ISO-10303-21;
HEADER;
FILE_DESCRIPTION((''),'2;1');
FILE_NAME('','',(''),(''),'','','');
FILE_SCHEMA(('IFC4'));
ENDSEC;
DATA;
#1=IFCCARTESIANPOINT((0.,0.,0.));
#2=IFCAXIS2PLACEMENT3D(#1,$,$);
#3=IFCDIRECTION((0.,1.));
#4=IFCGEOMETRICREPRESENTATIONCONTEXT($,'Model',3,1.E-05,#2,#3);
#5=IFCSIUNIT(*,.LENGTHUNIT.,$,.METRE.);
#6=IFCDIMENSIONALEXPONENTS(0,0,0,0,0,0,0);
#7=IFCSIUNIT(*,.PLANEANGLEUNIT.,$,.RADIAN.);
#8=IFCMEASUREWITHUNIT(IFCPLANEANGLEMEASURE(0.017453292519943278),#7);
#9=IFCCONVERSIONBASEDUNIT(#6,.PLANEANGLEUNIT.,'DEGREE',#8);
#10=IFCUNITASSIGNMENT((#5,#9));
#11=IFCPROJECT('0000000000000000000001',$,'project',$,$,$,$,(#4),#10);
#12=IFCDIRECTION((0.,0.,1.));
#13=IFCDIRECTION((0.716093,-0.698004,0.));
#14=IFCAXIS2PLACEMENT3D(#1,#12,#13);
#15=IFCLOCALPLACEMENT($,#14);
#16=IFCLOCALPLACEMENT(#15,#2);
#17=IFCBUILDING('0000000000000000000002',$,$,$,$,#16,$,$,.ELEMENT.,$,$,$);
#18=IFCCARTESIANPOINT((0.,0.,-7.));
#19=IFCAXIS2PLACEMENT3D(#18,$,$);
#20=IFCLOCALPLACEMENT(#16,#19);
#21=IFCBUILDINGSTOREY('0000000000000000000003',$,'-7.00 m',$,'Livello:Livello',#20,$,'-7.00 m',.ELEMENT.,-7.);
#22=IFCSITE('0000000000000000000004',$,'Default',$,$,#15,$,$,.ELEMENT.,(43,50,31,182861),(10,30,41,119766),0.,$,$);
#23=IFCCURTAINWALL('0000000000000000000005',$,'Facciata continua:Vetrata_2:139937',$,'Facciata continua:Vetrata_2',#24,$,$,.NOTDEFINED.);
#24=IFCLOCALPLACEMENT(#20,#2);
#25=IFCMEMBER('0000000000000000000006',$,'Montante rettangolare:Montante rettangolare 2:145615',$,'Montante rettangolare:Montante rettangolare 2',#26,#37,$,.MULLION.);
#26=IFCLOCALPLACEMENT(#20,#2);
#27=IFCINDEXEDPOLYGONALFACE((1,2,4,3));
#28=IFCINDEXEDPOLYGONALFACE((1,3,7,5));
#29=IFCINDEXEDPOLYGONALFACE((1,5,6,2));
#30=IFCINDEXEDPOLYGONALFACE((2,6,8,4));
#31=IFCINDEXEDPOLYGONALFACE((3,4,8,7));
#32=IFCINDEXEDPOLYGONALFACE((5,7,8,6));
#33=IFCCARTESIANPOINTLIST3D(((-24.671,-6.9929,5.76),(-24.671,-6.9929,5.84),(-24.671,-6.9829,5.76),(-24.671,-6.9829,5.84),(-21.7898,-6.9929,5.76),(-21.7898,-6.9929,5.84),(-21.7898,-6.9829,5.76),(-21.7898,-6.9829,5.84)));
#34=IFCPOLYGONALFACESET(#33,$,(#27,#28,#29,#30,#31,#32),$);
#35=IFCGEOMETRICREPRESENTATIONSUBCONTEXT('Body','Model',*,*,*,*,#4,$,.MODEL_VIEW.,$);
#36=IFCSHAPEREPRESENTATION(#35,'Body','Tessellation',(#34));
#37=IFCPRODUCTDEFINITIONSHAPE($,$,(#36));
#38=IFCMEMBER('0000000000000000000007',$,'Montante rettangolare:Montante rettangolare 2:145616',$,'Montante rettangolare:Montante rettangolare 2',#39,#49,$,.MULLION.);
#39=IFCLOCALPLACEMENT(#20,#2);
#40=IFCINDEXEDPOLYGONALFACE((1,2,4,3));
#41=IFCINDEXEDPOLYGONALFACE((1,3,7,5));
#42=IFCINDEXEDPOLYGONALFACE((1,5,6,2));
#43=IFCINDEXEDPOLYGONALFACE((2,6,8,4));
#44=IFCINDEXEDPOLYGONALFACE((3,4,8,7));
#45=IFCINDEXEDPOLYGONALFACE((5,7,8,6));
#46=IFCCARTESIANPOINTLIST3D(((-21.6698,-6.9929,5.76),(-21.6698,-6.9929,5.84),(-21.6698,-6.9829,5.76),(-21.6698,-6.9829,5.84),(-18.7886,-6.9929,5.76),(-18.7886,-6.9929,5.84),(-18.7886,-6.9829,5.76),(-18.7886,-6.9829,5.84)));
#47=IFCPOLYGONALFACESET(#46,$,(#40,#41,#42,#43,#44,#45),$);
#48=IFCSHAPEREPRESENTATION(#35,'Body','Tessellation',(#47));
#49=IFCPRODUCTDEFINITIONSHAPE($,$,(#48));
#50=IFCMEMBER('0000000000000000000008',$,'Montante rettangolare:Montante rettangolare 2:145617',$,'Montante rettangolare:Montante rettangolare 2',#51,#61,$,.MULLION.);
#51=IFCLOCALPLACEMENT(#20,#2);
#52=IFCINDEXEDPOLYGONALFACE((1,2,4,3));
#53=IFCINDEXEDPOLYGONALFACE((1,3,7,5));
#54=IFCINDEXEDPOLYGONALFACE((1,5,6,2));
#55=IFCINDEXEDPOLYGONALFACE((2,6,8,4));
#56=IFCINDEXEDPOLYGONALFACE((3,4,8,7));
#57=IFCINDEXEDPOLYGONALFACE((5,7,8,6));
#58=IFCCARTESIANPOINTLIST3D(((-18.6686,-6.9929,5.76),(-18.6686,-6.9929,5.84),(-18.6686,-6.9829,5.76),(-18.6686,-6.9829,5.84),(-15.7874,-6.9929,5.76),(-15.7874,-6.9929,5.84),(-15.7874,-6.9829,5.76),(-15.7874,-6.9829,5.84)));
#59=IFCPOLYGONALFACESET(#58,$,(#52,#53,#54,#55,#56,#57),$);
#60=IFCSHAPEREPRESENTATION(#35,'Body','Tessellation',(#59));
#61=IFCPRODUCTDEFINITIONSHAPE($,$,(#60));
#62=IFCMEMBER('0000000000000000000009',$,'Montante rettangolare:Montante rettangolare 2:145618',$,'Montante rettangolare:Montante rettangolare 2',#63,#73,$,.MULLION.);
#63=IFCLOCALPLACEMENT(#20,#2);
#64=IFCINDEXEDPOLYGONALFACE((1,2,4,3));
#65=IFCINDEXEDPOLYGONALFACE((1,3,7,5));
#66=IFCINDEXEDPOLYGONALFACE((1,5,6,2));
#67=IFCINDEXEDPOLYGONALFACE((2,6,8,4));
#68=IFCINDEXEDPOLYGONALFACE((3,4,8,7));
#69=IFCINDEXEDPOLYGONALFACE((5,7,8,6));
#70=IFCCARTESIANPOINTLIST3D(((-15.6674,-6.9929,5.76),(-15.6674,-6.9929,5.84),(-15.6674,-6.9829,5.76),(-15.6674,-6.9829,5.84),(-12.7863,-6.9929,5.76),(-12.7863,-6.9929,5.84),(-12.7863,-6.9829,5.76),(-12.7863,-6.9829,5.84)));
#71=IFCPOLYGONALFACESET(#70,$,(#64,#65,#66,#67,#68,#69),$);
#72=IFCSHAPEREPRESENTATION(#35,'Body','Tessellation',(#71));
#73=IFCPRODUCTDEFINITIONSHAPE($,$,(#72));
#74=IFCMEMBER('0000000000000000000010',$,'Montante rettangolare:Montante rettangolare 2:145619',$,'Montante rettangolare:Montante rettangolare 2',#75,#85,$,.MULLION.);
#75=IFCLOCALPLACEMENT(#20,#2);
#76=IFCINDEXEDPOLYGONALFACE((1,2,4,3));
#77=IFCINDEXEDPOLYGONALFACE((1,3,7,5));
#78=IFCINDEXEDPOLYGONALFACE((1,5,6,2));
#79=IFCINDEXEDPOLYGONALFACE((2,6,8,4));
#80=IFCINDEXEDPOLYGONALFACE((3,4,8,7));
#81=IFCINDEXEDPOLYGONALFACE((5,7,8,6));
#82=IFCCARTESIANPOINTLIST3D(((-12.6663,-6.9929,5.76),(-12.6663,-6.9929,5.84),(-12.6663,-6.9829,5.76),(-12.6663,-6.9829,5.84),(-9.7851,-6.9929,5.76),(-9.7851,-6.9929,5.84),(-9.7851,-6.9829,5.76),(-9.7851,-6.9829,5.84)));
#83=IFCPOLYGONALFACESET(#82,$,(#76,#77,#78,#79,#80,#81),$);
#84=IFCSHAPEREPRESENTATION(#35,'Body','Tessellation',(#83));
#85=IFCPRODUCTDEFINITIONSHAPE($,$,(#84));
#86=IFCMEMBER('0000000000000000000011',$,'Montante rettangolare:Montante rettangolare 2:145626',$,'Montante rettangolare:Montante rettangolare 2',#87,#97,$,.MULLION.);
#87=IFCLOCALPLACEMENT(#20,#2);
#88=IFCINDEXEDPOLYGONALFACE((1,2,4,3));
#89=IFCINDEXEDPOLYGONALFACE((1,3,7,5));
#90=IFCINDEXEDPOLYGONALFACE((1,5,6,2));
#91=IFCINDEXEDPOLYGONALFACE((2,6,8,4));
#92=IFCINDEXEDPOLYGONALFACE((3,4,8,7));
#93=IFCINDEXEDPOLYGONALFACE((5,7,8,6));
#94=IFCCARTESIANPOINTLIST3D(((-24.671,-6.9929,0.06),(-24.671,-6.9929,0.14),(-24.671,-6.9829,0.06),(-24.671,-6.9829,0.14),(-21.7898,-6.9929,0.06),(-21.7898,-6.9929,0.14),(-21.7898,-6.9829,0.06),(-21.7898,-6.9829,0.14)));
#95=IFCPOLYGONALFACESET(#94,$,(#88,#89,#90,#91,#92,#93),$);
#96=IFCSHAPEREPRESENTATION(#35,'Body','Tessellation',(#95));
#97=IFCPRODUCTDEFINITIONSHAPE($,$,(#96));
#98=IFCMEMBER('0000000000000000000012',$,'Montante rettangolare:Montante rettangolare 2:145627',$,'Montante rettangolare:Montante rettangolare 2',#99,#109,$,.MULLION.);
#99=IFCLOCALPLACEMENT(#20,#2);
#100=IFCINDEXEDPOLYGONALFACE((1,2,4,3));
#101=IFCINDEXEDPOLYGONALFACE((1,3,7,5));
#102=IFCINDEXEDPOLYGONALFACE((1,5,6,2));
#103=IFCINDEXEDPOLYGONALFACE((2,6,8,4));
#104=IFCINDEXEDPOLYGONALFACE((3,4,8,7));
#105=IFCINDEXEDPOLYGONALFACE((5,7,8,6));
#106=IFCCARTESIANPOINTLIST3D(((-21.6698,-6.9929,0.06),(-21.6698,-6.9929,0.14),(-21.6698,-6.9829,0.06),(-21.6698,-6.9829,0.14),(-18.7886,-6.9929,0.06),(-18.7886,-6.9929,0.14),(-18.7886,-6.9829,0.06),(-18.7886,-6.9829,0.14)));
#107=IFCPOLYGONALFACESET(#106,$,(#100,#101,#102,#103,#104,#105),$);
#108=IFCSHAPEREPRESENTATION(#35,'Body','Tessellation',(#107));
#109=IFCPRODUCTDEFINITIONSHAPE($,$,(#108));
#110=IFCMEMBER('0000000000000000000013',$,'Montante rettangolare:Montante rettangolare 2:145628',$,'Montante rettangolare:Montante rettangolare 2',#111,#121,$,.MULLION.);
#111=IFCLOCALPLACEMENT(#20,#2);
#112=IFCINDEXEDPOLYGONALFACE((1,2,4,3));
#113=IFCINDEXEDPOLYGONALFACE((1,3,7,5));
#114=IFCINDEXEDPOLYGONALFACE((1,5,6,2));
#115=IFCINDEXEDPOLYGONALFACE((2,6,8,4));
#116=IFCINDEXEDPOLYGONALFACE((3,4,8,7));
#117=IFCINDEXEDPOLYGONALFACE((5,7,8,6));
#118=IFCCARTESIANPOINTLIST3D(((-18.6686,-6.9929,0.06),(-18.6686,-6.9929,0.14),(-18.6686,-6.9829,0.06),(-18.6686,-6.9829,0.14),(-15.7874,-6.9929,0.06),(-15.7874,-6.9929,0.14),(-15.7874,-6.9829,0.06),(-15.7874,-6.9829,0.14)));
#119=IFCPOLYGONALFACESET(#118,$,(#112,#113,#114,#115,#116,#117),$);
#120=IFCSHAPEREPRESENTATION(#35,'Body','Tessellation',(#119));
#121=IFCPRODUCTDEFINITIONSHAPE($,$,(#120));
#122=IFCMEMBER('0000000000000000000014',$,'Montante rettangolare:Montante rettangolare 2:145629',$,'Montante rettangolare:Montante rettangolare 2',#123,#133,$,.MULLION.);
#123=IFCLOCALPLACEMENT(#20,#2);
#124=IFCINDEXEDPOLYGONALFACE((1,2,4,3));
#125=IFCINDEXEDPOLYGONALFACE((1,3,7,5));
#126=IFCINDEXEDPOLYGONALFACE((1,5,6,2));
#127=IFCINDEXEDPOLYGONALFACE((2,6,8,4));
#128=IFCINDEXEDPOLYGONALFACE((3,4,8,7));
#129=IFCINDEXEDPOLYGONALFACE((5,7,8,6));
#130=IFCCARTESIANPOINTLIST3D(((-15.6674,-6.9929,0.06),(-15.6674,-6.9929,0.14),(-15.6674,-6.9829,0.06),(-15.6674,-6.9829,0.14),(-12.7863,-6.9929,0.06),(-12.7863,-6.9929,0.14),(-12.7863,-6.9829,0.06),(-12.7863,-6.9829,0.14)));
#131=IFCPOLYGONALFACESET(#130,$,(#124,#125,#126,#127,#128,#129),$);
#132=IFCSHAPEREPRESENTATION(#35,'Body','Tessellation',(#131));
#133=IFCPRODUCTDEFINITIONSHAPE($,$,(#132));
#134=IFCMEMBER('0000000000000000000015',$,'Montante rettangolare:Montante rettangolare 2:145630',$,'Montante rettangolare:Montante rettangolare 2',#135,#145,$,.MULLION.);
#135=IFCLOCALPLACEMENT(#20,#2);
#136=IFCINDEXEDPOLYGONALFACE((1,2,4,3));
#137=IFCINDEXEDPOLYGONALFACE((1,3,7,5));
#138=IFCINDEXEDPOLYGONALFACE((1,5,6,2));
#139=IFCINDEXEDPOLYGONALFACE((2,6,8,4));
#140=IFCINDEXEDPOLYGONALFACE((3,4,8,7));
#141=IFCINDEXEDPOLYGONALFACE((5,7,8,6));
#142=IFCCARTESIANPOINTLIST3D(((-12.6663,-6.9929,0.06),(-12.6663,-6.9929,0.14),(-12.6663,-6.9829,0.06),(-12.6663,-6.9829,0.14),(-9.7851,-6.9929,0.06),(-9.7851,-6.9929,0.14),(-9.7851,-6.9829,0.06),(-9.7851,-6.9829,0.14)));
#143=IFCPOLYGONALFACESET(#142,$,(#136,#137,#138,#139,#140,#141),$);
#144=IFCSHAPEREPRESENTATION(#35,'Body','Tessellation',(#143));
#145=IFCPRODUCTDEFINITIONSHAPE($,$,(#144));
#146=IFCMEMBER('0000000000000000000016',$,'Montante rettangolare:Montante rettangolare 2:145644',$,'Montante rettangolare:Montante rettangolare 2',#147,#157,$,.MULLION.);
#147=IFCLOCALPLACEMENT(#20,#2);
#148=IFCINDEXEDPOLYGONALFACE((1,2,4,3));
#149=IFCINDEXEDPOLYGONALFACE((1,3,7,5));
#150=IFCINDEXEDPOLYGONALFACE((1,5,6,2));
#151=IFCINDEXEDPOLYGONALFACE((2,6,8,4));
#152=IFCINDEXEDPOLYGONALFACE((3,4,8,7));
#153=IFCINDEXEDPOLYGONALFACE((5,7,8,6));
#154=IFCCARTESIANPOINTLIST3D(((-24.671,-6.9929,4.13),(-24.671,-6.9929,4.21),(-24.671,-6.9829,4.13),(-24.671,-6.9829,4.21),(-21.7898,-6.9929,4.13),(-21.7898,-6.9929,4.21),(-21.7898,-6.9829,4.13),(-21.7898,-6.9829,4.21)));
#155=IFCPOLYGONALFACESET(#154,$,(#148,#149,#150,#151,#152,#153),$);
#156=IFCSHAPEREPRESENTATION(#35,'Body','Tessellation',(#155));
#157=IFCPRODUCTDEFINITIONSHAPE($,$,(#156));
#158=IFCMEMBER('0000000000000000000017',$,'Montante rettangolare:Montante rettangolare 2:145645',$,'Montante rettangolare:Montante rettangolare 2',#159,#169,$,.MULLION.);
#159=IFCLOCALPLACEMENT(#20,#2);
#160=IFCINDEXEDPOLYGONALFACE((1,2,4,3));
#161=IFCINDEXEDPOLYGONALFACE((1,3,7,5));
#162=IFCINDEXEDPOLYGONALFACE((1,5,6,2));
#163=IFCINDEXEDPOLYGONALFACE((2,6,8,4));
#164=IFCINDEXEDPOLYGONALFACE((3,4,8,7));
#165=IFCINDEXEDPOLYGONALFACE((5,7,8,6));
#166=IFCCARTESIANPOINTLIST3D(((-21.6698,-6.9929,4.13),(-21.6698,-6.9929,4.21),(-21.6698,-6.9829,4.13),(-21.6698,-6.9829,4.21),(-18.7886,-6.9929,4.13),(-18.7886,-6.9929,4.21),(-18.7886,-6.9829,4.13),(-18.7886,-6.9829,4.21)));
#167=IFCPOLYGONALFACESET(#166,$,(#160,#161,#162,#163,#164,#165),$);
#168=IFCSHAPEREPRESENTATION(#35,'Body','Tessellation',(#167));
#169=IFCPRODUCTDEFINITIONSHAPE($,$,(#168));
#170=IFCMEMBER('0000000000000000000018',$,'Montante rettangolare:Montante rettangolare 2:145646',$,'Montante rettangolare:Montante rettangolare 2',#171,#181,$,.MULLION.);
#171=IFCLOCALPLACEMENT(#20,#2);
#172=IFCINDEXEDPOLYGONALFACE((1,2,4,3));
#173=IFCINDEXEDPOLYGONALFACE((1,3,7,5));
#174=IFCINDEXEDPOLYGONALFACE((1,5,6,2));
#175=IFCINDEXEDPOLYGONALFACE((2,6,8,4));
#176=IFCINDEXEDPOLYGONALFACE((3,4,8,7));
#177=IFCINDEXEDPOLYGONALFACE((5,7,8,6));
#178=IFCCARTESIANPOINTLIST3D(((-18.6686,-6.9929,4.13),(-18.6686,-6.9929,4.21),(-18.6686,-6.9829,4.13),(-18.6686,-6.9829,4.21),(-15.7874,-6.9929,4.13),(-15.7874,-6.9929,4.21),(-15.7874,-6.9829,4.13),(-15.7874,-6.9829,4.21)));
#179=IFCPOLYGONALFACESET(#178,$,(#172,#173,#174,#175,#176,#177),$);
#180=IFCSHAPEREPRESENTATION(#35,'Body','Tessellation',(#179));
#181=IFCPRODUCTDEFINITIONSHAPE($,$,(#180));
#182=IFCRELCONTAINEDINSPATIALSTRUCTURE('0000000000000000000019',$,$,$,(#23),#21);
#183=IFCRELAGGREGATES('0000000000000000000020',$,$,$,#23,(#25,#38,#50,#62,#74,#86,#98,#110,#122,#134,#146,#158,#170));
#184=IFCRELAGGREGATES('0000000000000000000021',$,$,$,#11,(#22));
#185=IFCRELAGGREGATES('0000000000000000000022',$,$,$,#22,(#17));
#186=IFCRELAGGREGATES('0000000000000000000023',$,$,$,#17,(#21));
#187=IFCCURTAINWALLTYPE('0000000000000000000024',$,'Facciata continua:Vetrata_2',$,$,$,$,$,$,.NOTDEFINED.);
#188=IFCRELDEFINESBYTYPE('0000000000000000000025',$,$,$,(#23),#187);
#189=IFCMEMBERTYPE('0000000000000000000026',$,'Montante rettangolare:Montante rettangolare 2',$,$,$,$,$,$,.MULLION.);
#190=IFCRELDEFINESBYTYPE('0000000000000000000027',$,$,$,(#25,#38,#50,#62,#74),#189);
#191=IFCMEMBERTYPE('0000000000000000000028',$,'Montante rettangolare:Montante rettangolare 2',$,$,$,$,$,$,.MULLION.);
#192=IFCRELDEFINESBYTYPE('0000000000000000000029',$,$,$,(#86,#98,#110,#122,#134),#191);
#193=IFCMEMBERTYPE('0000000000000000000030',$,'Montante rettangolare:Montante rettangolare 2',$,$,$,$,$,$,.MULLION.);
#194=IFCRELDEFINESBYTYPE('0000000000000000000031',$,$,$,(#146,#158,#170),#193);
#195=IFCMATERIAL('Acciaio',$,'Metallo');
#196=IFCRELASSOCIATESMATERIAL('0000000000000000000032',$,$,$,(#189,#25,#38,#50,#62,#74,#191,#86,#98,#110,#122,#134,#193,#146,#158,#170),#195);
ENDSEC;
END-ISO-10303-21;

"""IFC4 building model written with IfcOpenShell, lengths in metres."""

from ifc_helpers import new_model, entity, si_unit, converted_unit, direction, frame, origin, place, context, subcontext, project, spatial, indexed_curve, outline, extrude, source, transform, mapped, material, type_object, type_shapes, element, aggregate, save


model = new_model("IFC4")

# Units and contexts
model_context = context("Model", 3, precision=1e-05, world=origin(), true_north=direction((0.0, 1.0)))
body_context = subcontext(model_context, "Body", "Model", "MODEL_VIEW")
ifc_project = project(units=[si_unit("LENGTHUNIT", "METRE"), converted_unit("PLANEANGLEUNIT", "DEGREE", entity("IfcPlaneAngleMeasure", 0.017453292519943278), si_unit("PLANEANGLEUNIT", "RADIAN"), dimensions=[0, 0, 0, 0, 0, 0, 0])], contexts=[model_context])

# Site, building, storey
site_placement = place(None, frame((0.0, 0.0, 0.0), z_axis=(0.0, 0.0, 1.0), x_axis=(0.716093, -0.698004, 0.0)))
site = spatial("IfcSite", under=ifc_project, at=site_placement, Name="Default", CompositionType="ELEMENT", RefLatitude=(43, 50, 31, 182861), RefLongitude=(10, 30, 41, 119766), RefElevation=0.0)
building_placement = place(site_placement, origin())
building = spatial("IfcBuilding", under=site, at=building_placement, CompositionType="ELEMENT")
storey_placement = place(building_placement, frame((0.0, 0.0, -7.0)))
storey = spatial("IfcBuildingStorey", under=building, at=storey_placement, Name="-7.00 m", ObjectType="Livello:Livello", LongName="-7.00 m", CompositionType="ELEMENT", Elevation=-7.0)

# Curtain wall, members
curtain_wall_type = type_object("IfcCurtainWallType", Name="Facciata continua:Vetrata_2", PredefinedType="NOTDEFINED")
curtain_wall_placement = place(storey_placement, frame((0.0, 0.0, 7.0)))
curtain_wall = element("IfcCurtainWall", 1, at=curtain_wall_placement, inside=storey, type_object=curtain_wall_type, Name="Facciata continua:Vetrata_2:139937", ObjectType="Facciata continua:Vetrata_2", PredefinedType="NOTDEFINED")
ifc_material = material(Name="Acciaio", Category="Metallo")
member_type_1 = type_object("IfcMemberType", Name="Montante rettangolare:Montante rettangolare 2", PredefinedType="MULLION", material=ifc_material)
shared_shape_1 = source(origin(), body_context, "Body", "SweptSolid", [
    extrude(outline(indexed_curve([(-0.04, -0.005), (0.04, -0.005), (0.04, 0.005), (-0.04, 0.005), (-0.04, -0.005)], self_intersect=False)), frame((-0.04, 0.01, -2.8812), z_axis=(0.0, 0.0, 1.0), x_axis=(-1.0, 0.0, 0.0)), (0.0, 0.0, 1.0), 2.8812),
])
type_shapes(member_type_1, [shared_shape_1])
member_1_placement = place(curtain_wall_placement, frame((-21.7898, -6.9779, -1.16), z_axis=(1.0, 0.0, 0.0), x_axis=(0.0, 0.0, 1.0)))
member_1 = element("IfcMember", 2, at=member_1_placement, type_object=member_type_1, material=ifc_material, Name="Montante rettangolare:Montante rettangolare 2:145615", ObjectType="Montante rettangolare:Montante rettangolare 2", PredefinedType="MULLION", context=body_context, shape_type="MappedRepresentation", body=[
    mapped(shared_shape_1, transform((0.0, 0.0, 0.0), scale=1.0)),
])
member_2_placement = place(curtain_wall_placement, frame((-18.7886, -6.9779, -1.16), z_axis=(1.0, 0.0, 0.0), x_axis=(0.0, 0.0, 1.0)))
member_2 = element("IfcMember", 3, at=member_2_placement, type_object=member_type_1, material=ifc_material, Name="Montante rettangolare:Montante rettangolare 2:145616", ObjectType="Montante rettangolare:Montante rettangolare 2", PredefinedType="MULLION", context=body_context, shape_type="MappedRepresentation", body=[
    mapped(shared_shape_1, transform((0.0, 0.0, 0.0), scale=1.0)),
])
member_3_placement = place(curtain_wall_placement, frame((-15.7874, -6.9779, -1.16), z_axis=(1.0, 0.0, 0.0), x_axis=(0.0, 0.0, 1.0)))
member_3 = element("IfcMember", 4, at=member_3_placement, type_object=member_type_1, material=ifc_material, Name="Montante rettangolare:Montante rettangolare 2:145617", ObjectType="Montante rettangolare:Montante rettangolare 2", PredefinedType="MULLION", context=body_context, shape_type="MappedRepresentation", body=[
    mapped(shared_shape_1, transform((0.0, 0.0, 0.0), scale=1.0)),
])
member_4_placement = place(curtain_wall_placement, frame((-12.7863, -6.9779, -1.16), z_axis=(1.0, 0.0, 0.0), x_axis=(0.0, 0.0, 1.0)))
member_4 = element("IfcMember", 5, at=member_4_placement, type_object=member_type_1, material=ifc_material, Name="Montante rettangolare:Montante rettangolare 2:145618", ObjectType="Montante rettangolare:Montante rettangolare 2", PredefinedType="MULLION", context=body_context, shape_type="MappedRepresentation", body=[
    mapped(shared_shape_1, transform((0.0, 0.0, 0.0), scale=1.0)),
])
member_5_placement = place(curtain_wall_placement, frame((-9.7851, -6.9779, -1.16), z_axis=(1.0, 0.0, 0.0), x_axis=(0.0, 0.0, 1.0)))
member_5 = element("IfcMember", 6, at=member_5_placement, type_object=member_type_1, material=ifc_material, Name="Montante rettangolare:Montante rettangolare 2:145619", ObjectType="Montante rettangolare:Montante rettangolare 2", PredefinedType="MULLION", context=body_context, shape_type="MappedRepresentation", body=[
    mapped(shared_shape_1, transform((0.0, 0.0, 0.0), scale=1.0)),
])
member_type_2 = type_object("IfcMemberType", Name="Montante rettangolare:Montante rettangolare 2", PredefinedType="MULLION", material=ifc_material)
shared_shape_2 = source(origin(), body_context, "Body", "SweptSolid", [
    extrude(outline(indexed_curve([(-0.04, -0.005), (0.04, -0.005), (0.04, 0.005), (-0.04, 0.005), (-0.04, -0.005)], self_intersect=False)), frame((-0.04, 0.01, -2.8812), z_axis=(0.0, 0.0, 1.0), x_axis=(-1.0, 0.0, 0.0)), (0.0, 0.0, 1.0), 2.8812),
])
type_shapes(member_type_2, [shared_shape_2])
member_6_placement = place(curtain_wall_placement, frame((-24.671, -6.9779, -6.94), z_axis=(-1.0, 0.0, 0.0), x_axis=(0.0, 0.0, -1.0)))
member_6 = element("IfcMember", 7, at=member_6_placement, type_object=member_type_2, material=ifc_material, Name="Montante rettangolare:Montante rettangolare 2:145626", ObjectType="Montante rettangolare:Montante rettangolare 2", PredefinedType="MULLION", context=body_context, shape_type="MappedRepresentation", body=[
    mapped(shared_shape_2, transform((0.0, 0.0, 0.0), scale=1.0)),
])
member_7_placement = place(curtain_wall_placement, frame((-21.6698, -6.9779, -6.94), z_axis=(-1.0, 0.0, 0.0), x_axis=(0.0, 0.0, -1.0)))
member_7 = element("IfcMember", 8, at=member_7_placement, type_object=member_type_2, material=ifc_material, Name="Montante rettangolare:Montante rettangolare 2:145627", ObjectType="Montante rettangolare:Montante rettangolare 2", PredefinedType="MULLION", context=body_context, shape_type="MappedRepresentation", body=[
    mapped(shared_shape_2, transform((0.0, 0.0, 0.0), scale=1.0)),
])
member_8_placement = place(curtain_wall_placement, frame((-18.6686, -6.9779, -6.94), z_axis=(-1.0, 0.0, 0.0), x_axis=(0.0, 0.0, -1.0)))
member_8 = element("IfcMember", 9, at=member_8_placement, type_object=member_type_2, material=ifc_material, Name="Montante rettangolare:Montante rettangolare 2:145628", ObjectType="Montante rettangolare:Montante rettangolare 2", PredefinedType="MULLION", context=body_context, shape_type="MappedRepresentation", body=[
    mapped(shared_shape_2, transform((0.0, 0.0, 0.0), scale=1.0)),
])
member_9_placement = place(curtain_wall_placement, frame((-15.6674, -6.9779, -6.94), z_axis=(-1.0, 0.0, 0.0), x_axis=(0.0, 0.0, -1.0)))
member_9 = element("IfcMember", 10, at=member_9_placement, type_object=member_type_2, material=ifc_material, Name="Montante rettangolare:Montante rettangolare 2:145629", ObjectType="Montante rettangolare:Montante rettangolare 2", PredefinedType="MULLION", context=body_context, shape_type="MappedRepresentation", body=[
    mapped(shared_shape_2, transform((0.0, 0.0, 0.0), scale=1.0)),
])
member_10_placement = place(curtain_wall_placement, frame((-12.6663, -6.9779, -6.94), z_axis=(-1.0, 0.0, 0.0), x_axis=(0.0, 0.0, -1.0)))
member_10 = element("IfcMember", 11, at=member_10_placement, type_object=member_type_2, material=ifc_material, Name="Montante rettangolare:Montante rettangolare 2:145630", ObjectType="Montante rettangolare:Montante rettangolare 2", PredefinedType="MULLION", context=body_context, shape_type="MappedRepresentation", body=[
    mapped(shared_shape_2, transform((0.0, 0.0, 0.0), scale=1.0)),
])
member_type_3 = type_object("IfcMemberType", Name="Montante rettangolare:Montante rettangolare 2", PredefinedType="MULLION", material=ifc_material)
shared_shape_3 = source(origin(), body_context, "Body", "SweptSolid", [
    extrude(outline(indexed_curve([(-0.04, -0.005), (0.04, -0.005), (0.04, 0.005), (-0.04, 0.005), (-0.04, -0.005)], self_intersect=False)), frame((0.0, 0.01, -2.8812), z_axis=(0.0, 0.0, 1.0), x_axis=(-1.0, 0.0, 0.0)), (0.0, 0.0, 1.0), 2.8812),
])
type_shapes(member_type_3, [shared_shape_3])
member_11_placement = place(curtain_wall_placement, frame((-21.7898, -6.9779, -2.83), z_axis=(1.0, 0.0, 0.0), x_axis=(0.0, 0.0, 1.0)))
member_11 = element("IfcMember", 12, at=member_11_placement, type_object=member_type_3, material=ifc_material, Name="Montante rettangolare:Montante rettangolare 2:145644", ObjectType="Montante rettangolare:Montante rettangolare 2", PredefinedType="MULLION", context=body_context, shape_type="MappedRepresentation", body=[
    mapped(shared_shape_3, transform((0.0, 0.0, 0.0), scale=1.0)),
])
member_12_placement = place(curtain_wall_placement, frame((-18.7886, -6.9779, -2.83), z_axis=(1.0, 0.0, 0.0), x_axis=(0.0, 0.0, 1.0)))
member_12 = element("IfcMember", 13, at=member_12_placement, type_object=member_type_3, material=ifc_material, Name="Montante rettangolare:Montante rettangolare 2:145645", ObjectType="Montante rettangolare:Montante rettangolare 2", PredefinedType="MULLION", context=body_context, shape_type="MappedRepresentation", body=[
    mapped(shared_shape_3, transform((0.0, 0.0, 0.0), scale=1.0)),
])
member_13_placement = place(curtain_wall_placement, frame((-15.7874, -6.9779, -2.83), z_axis=(1.0, 0.0, 0.0), x_axis=(0.0, 0.0, 1.0)))
member_13 = element("IfcMember", 14, at=member_13_placement, type_object=member_type_3, material=ifc_material, Name="Montante rettangolare:Montante rettangolare 2:145646", ObjectType="Montante rettangolare:Montante rettangolare 2", PredefinedType="MULLION", context=body_context, shape_type="MappedRepresentation", body=[
    mapped(shared_shape_3, transform((0.0, 0.0, 0.0), scale=1.0)),
])
aggregate(curtain_wall, [member_1, member_2, member_3, member_4, member_5, member_6, member_7, member_8, member_9, member_10, member_11, member_12, member_13])

save(model, "model.ifc")
